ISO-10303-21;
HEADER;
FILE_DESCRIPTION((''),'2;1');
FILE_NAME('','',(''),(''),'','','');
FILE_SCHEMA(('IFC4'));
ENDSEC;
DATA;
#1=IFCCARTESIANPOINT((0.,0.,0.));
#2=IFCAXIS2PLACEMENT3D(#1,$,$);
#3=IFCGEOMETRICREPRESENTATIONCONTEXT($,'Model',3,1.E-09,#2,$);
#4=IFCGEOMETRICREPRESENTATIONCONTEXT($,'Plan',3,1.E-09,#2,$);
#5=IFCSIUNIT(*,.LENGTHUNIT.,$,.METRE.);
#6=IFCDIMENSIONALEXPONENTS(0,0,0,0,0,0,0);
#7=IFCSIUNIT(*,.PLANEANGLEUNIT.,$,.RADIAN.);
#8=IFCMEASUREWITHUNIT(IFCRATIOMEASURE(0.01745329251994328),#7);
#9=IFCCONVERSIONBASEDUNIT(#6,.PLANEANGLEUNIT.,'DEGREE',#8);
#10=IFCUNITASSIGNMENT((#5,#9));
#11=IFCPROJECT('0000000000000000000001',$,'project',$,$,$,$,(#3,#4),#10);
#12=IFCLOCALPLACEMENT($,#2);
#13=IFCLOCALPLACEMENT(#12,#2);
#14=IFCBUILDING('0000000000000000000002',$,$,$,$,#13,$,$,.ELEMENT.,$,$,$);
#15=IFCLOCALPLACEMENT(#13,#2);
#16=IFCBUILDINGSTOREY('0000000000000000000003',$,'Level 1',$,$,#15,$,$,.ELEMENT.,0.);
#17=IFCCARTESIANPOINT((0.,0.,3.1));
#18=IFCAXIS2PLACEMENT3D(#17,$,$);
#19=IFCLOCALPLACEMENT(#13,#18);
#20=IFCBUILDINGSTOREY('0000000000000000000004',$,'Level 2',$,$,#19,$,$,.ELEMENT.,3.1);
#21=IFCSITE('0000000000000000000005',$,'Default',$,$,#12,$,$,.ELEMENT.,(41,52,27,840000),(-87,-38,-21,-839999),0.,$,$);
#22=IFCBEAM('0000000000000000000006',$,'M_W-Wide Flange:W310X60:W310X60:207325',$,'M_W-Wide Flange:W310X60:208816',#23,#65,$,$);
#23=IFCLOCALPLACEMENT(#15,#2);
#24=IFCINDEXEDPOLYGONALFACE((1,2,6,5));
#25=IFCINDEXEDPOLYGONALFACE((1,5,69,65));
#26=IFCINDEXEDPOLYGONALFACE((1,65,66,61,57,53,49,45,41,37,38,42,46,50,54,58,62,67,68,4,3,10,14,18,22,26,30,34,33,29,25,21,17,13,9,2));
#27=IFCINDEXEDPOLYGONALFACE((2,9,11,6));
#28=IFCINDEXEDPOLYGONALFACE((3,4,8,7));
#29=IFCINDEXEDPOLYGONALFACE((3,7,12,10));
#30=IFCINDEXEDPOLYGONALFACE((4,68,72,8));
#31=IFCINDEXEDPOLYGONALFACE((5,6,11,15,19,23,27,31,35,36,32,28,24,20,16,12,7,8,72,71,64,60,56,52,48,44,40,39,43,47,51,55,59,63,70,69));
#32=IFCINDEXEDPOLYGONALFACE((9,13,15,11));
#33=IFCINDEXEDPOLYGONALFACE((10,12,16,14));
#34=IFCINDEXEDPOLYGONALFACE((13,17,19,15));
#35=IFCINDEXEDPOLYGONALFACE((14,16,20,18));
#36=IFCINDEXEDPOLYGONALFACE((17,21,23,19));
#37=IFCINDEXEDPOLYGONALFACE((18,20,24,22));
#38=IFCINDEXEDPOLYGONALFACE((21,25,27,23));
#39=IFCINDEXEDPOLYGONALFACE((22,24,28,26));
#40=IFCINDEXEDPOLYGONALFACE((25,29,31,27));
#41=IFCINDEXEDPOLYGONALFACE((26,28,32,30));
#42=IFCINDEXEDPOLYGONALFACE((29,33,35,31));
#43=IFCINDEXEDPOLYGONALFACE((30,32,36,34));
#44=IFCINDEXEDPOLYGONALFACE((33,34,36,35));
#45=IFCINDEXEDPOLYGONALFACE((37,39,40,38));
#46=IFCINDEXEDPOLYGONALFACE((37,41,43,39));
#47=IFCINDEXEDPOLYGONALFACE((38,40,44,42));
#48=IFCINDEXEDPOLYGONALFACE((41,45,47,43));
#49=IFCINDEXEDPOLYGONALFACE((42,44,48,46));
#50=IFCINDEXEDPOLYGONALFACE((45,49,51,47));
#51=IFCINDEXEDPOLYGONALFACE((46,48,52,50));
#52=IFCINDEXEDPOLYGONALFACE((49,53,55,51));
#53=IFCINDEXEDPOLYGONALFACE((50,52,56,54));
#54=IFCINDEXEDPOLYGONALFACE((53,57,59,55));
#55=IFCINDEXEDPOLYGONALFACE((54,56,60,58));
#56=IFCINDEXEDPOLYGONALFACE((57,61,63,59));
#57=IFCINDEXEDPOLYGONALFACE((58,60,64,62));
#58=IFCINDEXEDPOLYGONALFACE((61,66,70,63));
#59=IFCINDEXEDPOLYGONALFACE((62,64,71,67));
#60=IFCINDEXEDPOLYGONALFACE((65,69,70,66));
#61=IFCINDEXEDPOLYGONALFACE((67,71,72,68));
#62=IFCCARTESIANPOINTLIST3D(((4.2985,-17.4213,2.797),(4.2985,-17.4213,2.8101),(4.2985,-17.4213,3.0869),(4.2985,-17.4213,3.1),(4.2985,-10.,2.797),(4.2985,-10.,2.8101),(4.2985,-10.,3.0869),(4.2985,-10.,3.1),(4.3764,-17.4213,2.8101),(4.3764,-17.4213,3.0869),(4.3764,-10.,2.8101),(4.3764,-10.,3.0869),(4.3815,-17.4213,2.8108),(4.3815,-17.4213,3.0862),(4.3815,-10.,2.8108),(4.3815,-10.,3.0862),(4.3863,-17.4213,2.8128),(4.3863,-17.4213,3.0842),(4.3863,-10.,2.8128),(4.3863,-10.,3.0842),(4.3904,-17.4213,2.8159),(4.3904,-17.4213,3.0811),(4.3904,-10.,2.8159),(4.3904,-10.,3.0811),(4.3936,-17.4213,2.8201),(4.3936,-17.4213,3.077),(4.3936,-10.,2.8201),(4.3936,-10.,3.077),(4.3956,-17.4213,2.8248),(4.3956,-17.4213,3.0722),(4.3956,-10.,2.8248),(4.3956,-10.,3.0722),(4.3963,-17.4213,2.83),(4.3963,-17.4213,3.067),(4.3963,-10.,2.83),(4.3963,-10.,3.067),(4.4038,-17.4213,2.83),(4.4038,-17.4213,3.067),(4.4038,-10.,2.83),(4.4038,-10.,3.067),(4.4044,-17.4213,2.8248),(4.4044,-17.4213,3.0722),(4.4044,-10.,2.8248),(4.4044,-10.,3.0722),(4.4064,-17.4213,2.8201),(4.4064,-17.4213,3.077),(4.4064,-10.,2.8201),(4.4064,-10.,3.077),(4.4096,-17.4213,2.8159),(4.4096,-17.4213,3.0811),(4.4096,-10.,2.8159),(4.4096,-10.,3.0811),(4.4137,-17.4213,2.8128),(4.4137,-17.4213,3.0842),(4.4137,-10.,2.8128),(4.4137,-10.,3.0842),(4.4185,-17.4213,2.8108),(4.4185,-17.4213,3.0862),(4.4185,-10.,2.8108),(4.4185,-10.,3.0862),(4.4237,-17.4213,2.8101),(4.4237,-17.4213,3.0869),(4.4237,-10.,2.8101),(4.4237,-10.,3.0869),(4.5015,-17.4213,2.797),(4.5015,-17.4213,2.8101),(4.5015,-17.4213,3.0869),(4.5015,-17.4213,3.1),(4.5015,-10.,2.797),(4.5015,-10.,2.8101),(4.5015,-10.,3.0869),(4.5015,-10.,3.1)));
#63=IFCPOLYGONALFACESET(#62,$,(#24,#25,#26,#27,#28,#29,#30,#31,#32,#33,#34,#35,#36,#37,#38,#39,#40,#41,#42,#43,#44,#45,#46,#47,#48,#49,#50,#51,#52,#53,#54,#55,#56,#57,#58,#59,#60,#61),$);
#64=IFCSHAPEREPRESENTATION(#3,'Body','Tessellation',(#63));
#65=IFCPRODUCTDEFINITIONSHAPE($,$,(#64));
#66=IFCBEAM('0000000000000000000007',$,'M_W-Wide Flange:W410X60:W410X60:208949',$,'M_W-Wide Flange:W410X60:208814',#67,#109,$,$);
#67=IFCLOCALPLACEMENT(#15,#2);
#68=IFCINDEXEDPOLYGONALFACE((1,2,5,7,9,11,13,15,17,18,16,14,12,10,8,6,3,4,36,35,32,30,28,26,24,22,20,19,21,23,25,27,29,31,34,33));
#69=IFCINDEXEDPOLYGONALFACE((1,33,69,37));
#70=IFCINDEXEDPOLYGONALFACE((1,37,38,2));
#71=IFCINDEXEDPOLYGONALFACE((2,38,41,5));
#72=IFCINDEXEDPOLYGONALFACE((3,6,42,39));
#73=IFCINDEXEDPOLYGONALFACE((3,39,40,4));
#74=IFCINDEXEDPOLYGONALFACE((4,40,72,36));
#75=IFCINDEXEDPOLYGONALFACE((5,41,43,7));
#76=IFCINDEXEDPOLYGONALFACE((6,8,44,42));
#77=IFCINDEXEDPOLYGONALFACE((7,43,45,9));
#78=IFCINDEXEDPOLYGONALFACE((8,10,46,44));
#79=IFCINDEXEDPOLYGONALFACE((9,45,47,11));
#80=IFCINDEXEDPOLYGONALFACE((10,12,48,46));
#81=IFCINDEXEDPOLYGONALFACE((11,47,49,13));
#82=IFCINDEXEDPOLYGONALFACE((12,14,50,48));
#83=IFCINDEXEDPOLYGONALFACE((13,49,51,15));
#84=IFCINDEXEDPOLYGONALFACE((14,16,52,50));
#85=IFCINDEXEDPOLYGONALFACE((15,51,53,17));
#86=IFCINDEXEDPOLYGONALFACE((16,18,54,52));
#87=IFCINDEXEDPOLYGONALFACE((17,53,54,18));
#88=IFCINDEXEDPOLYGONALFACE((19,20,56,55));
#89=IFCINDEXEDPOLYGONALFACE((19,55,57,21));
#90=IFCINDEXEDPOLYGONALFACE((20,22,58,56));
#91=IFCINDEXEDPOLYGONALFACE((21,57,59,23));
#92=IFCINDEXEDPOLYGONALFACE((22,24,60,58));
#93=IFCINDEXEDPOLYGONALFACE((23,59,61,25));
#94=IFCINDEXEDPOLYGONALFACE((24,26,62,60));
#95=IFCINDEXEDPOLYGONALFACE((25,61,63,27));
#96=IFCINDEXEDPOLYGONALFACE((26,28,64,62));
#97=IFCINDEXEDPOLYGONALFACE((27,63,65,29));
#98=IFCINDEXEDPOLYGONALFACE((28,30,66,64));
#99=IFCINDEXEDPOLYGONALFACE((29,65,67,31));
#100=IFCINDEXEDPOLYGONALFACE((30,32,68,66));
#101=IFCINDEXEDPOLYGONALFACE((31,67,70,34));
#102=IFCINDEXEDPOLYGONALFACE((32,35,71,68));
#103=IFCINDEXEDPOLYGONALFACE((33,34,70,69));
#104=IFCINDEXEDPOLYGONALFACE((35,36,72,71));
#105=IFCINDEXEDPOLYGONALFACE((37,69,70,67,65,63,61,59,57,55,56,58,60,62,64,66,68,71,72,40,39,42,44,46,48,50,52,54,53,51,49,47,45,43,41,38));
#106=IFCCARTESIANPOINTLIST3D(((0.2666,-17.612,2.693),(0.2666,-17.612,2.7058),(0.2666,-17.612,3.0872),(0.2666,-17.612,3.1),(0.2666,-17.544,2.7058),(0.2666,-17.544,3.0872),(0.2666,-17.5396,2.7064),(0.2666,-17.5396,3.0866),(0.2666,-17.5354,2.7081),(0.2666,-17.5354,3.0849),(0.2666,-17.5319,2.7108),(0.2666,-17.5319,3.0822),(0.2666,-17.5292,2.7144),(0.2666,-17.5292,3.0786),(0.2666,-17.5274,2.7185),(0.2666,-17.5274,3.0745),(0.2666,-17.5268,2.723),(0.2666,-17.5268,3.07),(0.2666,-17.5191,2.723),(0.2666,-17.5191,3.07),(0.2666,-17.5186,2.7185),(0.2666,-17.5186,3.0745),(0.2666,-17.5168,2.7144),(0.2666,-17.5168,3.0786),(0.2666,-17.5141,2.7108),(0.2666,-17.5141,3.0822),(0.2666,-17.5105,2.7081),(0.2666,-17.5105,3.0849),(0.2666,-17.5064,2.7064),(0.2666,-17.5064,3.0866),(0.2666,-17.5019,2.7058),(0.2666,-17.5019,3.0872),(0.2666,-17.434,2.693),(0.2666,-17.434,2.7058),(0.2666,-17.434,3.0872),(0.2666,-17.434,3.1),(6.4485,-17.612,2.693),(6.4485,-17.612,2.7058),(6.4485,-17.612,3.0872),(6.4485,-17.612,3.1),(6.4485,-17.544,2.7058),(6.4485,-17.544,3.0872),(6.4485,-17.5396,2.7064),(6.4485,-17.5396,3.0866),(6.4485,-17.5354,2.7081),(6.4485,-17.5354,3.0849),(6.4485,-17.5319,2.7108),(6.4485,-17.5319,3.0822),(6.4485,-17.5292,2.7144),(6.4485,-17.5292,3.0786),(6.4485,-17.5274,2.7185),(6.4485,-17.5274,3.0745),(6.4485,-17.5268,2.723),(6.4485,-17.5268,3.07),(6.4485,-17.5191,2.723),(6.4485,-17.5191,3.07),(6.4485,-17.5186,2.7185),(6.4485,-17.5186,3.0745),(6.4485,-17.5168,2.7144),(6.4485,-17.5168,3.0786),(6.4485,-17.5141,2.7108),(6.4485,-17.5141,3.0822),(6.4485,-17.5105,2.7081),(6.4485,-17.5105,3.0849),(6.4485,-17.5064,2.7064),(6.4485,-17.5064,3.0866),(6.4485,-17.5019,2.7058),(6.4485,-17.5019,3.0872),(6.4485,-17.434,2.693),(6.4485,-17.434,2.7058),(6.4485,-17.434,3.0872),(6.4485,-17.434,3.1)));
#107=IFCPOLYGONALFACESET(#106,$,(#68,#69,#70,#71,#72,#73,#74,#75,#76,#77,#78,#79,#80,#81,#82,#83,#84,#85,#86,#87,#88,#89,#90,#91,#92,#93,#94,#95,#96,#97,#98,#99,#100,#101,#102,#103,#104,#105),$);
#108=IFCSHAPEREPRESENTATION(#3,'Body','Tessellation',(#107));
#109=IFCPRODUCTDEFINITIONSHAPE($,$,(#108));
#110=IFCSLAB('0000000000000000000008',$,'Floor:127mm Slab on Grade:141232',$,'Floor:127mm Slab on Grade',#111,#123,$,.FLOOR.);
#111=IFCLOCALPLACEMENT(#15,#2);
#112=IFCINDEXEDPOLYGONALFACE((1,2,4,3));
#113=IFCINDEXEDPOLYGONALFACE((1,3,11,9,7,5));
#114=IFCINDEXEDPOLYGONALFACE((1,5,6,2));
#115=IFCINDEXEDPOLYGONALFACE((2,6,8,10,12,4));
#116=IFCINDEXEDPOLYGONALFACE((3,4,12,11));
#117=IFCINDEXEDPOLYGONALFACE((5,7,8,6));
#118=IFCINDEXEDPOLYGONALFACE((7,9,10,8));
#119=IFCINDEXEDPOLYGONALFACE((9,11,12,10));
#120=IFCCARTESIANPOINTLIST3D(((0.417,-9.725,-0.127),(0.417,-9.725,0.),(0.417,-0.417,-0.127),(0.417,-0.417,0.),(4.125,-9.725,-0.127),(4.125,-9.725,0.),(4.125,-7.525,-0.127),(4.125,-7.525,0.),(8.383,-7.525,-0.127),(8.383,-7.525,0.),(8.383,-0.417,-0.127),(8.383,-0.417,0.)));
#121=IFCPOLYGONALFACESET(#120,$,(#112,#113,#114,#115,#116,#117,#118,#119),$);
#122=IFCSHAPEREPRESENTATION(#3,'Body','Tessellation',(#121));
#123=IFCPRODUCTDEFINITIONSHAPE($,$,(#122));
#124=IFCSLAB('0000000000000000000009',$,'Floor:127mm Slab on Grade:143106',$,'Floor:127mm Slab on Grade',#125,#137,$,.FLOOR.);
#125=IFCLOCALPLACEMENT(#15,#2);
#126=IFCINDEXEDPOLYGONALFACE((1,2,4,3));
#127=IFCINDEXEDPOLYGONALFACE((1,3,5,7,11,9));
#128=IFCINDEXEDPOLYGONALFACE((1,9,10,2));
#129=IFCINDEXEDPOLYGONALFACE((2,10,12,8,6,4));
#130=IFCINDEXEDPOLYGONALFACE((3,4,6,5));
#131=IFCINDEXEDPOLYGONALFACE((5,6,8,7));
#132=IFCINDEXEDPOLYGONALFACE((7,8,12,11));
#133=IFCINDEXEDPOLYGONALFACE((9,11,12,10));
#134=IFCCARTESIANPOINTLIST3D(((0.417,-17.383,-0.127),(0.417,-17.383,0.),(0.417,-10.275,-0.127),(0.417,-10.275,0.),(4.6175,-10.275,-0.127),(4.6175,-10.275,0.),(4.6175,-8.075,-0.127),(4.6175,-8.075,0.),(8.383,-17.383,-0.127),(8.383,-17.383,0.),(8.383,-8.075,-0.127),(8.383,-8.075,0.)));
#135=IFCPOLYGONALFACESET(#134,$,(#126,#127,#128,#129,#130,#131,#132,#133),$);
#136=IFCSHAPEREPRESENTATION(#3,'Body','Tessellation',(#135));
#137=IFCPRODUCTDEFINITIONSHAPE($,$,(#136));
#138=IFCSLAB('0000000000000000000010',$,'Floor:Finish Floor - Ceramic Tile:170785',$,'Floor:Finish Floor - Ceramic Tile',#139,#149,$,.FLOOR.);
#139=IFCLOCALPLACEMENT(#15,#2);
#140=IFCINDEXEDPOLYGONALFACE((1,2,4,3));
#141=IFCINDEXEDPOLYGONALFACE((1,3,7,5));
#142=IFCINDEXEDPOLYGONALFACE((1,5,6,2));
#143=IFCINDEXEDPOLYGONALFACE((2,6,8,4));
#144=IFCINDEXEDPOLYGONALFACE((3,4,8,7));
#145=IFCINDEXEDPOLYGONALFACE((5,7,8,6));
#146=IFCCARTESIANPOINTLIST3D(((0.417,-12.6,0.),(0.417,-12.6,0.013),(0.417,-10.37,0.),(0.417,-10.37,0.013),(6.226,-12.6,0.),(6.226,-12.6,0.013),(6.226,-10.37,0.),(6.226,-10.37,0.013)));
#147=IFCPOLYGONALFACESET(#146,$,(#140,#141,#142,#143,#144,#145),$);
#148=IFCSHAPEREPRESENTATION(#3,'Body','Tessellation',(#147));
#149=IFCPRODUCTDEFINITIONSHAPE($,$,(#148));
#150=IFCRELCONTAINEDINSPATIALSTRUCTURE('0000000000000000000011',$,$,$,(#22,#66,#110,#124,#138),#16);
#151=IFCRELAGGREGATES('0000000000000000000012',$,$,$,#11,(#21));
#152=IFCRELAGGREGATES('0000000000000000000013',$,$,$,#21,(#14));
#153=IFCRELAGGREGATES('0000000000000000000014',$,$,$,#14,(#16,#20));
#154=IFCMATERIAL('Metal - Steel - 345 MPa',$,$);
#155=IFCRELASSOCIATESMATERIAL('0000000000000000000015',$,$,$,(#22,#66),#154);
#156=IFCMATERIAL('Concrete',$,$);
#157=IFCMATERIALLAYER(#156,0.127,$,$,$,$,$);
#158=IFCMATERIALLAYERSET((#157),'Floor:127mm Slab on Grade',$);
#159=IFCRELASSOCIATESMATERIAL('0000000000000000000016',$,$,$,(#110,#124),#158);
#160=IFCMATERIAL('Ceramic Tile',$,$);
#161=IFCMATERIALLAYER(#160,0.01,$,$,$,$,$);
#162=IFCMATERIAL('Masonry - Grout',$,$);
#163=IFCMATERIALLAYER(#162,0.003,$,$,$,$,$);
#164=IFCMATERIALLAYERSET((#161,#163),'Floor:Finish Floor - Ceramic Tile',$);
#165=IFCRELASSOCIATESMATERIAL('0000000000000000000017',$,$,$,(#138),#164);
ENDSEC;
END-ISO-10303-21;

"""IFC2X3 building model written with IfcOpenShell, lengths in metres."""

from ifc_helpers import new_model, entity, si_unit, converted_unit, frame, frame_2d, origin, place, context, project, spatial, polyline, circle_curve, parameter, trimmed, segment, composite_curve, rectangle, outline, extrude, material, layer, layer_set, layer_usage, element, save


model = new_model("IFC2X3")

# Units and contexts
model_context = context("Model", 3, precision=1e-09, world=origin())
plan_context = context("Plan", 3, precision=1e-09, world=origin())
ifc_project = project(units=[si_unit("LENGTHUNIT", "METRE"), converted_unit("PLANEANGLEUNIT", "DEGREE", entity("IfcRatioMeasure", 0.01745329251994328), si_unit("PLANEANGLEUNIT", "RADIAN"), dimensions=[0, 0, 0, 0, 0, 0, 0])], contexts=[model_context, plan_context])

# Site, building, storey
site_placement = place(None, origin())
site = spatial("IfcSite", under=ifc_project, at=site_placement, Name="Default", CompositionType="ELEMENT", RefLatitude=(41, 52, 27, 840000), RefLongitude=(-87, -38, -21, -839999), RefElevation=0.0)
building_placement = place(site_placement, origin())
building = spatial("IfcBuilding", under=site, at=building_placement, CompositionType="ELEMENT")
storey_1_placement = place(building_placement, origin())
storey_1 = spatial("IfcBuildingStorey", under=building, at=storey_1_placement, Name="Level 1", CompositionType="ELEMENT", Elevation=0.0)

# Beams
ifc_material_1 = material(Name="Metal - Steel - 345 MPa")
beam_1_placement = place(storey_1_placement, frame((4.4, -10.0, 3.1), z_axis=(0.0, 0.0, 1.0), x_axis=(-1.0, 0.0, 0.0)))
element("IfcBeam", 1, at=beam_1_placement, inside=storey_1, material=ifc_material_1, Name="M_W-Wide Flange:W310X60:W310X60:207325", ObjectType="M_W-Wide Flange:W310X60:208816", context=model_context, shape_type="SweptSolid", body=[
    extrude(outline(composite_curve([segment(polyline([(0.1384, -0.1015), (0.1515, -0.1015)]), True, "CONTINUOUS"), segment(polyline([(0.1515, -0.1015), (0.1515, 0.1015)]), True, "CONTINUOUS"), segment(polyline([(0.1515, 0.1015), (0.1384, 0.1015)]), True, "CONTINUOUS"), segment(polyline([(0.1384, 0.1015), (0.1384, 0.0236)]), True, "CONTINUOUS"), segment(trimmed(circle_curve(frame_2d((0.1185, 0.0236), x_axis=(0.0, 1.0)), 0.0199), [parameter(180.0)], [parameter(270.0)], True, "PARAMETER"), False, "CONTINUOUS"), segment(polyline([(0.1185, 0.0037), (-0.1185, 0.0037)]), True, "CONTINUOUS"), segment(trimmed(circle_curve(frame_2d((-0.1185, 0.0236), x_axis=(0.0, 1.0)), 0.0199), [parameter(90.0)], [parameter(180.0)], True, "PARAMETER"), False, "CONTINUOUS"), segment(polyline([(-0.1384, 0.0236), (-0.1384, 0.1015)]), True, "CONTINUOUS"), segment(polyline([(-0.1384, 0.1015), (-0.1515, 0.1015)]), True, "CONTINUOUS"), segment(polyline([(-0.1515, 0.1015), (-0.1515, -0.1015)]), True, "CONTINUOUS"), segment(polyline([(-0.1515, -0.1015), (-0.1384, -0.1015)]), True, "CONTINUOUS"), segment(polyline([(-0.1384, -0.1015), (-0.1384, -0.0237)]), True, "CONTINUOUS"), segment(trimmed(circle_curve(frame_2d((-0.1185, -0.0237), x_axis=(0.0, 1.0)), 0.0199), [parameter(360.0)], [parameter(90.0)], True, "PARAMETER"), False, "CONTINUOUS"), segment(polyline([(-0.1185, -0.0038), (0.1185, -0.0038)]), True, "CONTINUOUS"), segment(trimmed(circle_curve(frame_2d((0.1185, -0.0237), x_axis=(0.0, 1.0)), 0.0199), [parameter(270.0)], [parameter(0.0)], True, "PARAMETER"), False, "CONTINUOUS"), segment(polyline([(0.1384, -0.0237), (0.1384, -0.1015)]), True, "CONTINUOUS")], self_intersect=False)), frame((0.0, 7.4213, -0.1515), z_axis=(0.0, -1.0, 0.0), x_axis=(0.0, 0.0, -1.0)), (0.0, 0.0, 1.0), 7.4213),
])
beam_2_placement = place(storey_1_placement, frame((0.2085, -17.523, 3.1), z_axis=(0.0, 0.0, 1.0), x_axis=(0.0, -1.0, 0.0)))
element("IfcBeam", 2, at=beam_2_placement, inside=storey_1, material=ifc_material_1, Name="M_W-Wide Flange:W410X60:W410X60:208949", ObjectType="M_W-Wide Flange:W410X60:208814", context=model_context, shape_type="SweptSolid", body=[
    extrude(outline(composite_curve([segment(polyline([(-0.089, -0.1907), (-0.089, -0.2035)]), True, "CONTINUOUS"), segment(polyline([(-0.089, -0.2035), (0.089, -0.2035)]), True, "CONTINUOUS"), segment(polyline([(0.089, -0.2035), (0.089, -0.1907)]), True, "CONTINUOUS"), segment(polyline([(0.089, -0.1907), (0.021, -0.1907)]), True, "CONTINUOUS"), segment(trimmed(circle_curve(frame_2d((0.021, -0.1735), x_axis=(0.0, -1.0)), 0.0172), [parameter(270.0)], [parameter(360.0)], True, "PARAMETER"), False, "CONTINUOUS"), segment(polyline([(0.0038, -0.1735), (0.0038, 0.1735)]), True, "CONTINUOUS"), segment(trimmed(circle_curve(frame_2d((0.021, 0.1735), x_axis=(-1.0, 0.0)), 0.0172), [parameter(270.0)], [parameter(360.0)], True, "PARAMETER"), False, "CONTINUOUS"), segment(polyline([(0.021, 0.1907), (0.089, 0.1907)]), True, "CONTINUOUS"), segment(polyline([(0.089, 0.1907), (0.089, 0.2035)]), True, "CONTINUOUS"), segment(polyline([(0.089, 0.2035), (-0.089, 0.2035)]), True, "CONTINUOUS"), segment(polyline([(-0.089, 0.2035), (-0.089, 0.1907)]), True, "CONTINUOUS"), segment(polyline([(-0.089, 0.1907), (-0.0211, 0.1907)]), True, "CONTINUOUS"), segment(trimmed(circle_curve(frame_2d((-0.0211, 0.1735), x_axis=(0.0, 1.0)), 0.0172), [parameter(270.0)], [parameter(0.0)], True, "PARAMETER"), False, "CONTINUOUS"), segment(polyline([(-0.0039, 0.1735), (-0.0039, -0.1735)]), True, "CONTINUOUS"), segment(trimmed(circle_curve(frame_2d((-0.0211, -0.1735), x_axis=(1.0, 0.0)), 0.0172), [parameter(270.0)], [parameter(0.0)], True, "PARAMETER"), False, "CONTINUOUS"), segment(polyline([(-0.0211, -0.1907), (-0.089, -0.1907)]), True, "CONTINUOUS")], self_intersect=False)), frame((0.0, 0.0581, -0.2035), z_axis=(0.0, -1.0, 0.0), x_axis=(1.0, 0.0, 0.0)), (0.0, 0.0, -1.0), 6.1819),
])

# Slabs
ifc_material_2 = material(Name="Concrete")
ifc_layer_1 = layer(ifc_material_2, 0.127)
ifc_layer_set_1 = layer_set([ifc_layer_1], Name="Floor:127mm Slab on Grade")
ifc_layer_usage_1 = layer_usage(ifc_layer_set_1, "AXIS3", "POSITIVE", 0.0)
slab_1_placement = place(storey_1_placement, frame((0.417, -9.725, -0.127)))
element("IfcSlab", 3, at=slab_1_placement, inside=storey_1, material=ifc_layer_usage_1, Name="Floor:127mm Slab on Grade:141232", ObjectType="Floor:127mm Slab on Grade", PredefinedType="FLOOR", context=model_context, shape_type="SweptSolid", body=[
    extrude(outline(polyline([(-3.983, 4.654), (-3.983, -2.454), (0.275, -2.454), (0.275, -4.654), (3.983, -4.654), (3.983, 4.654), (-3.983, 4.654)])), frame((3.983, 4.654, 0.127), z_axis=(0.0, 0.0, -1.0), x_axis=(-1.0, 0.0, 0.0)), (0.0, 0.0, 1.0), 0.127),
])
ifc_layer_usage_2 = layer_usage(ifc_layer_set_1, "AXIS3", "POSITIVE", 0.0)
slab_2_placement = place(storey_1_placement, frame((0.417, -17.383, -0.127)))
element("IfcSlab", 4, at=slab_2_placement, inside=storey_1, material=ifc_layer_usage_2, Name="Floor:127mm Slab on Grade:143106", ObjectType="Floor:127mm Slab on Grade", PredefinedType="FLOOR", context=model_context, shape_type="SweptSolid", body=[
    extrude(outline(polyline([(-3.983, 4.654), (-3.983, -4.654), (3.983, -4.654), (3.983, 2.454), (-0.2175, 2.454), (-0.2175, 4.654), (-3.983, 4.654)])), frame((3.983, 4.654, 0.127), z_axis=(0.0, 0.0, -1.0), x_axis=(-1.0, 0.0, 0.0)), (0.0, 0.0, 1.0), 0.127),
])
ifc_material_3 = material(Name="Ceramic Tile")
ifc_layer_2 = layer(ifc_material_3, 0.01)
ifc_material_4 = material(Name="Masonry - Grout")
ifc_layer_3 = layer(ifc_material_4, 0.003)
ifc_layer_set_2 = layer_set([ifc_layer_2, ifc_layer_3], Name="Floor:Finish Floor - Ceramic Tile")
ifc_layer_usage_3 = layer_usage(ifc_layer_set_2, "AXIS3", "POSITIVE", 0.0)
slab_3_placement = place(storey_1_placement, frame((0.417, -12.6, 0.0)))
element("IfcSlab", 5, at=slab_3_placement, inside=storey_1, material=ifc_layer_usage_3, Name="Floor:Finish Floor - Ceramic Tile:170785", ObjectType="Floor:Finish Floor - Ceramic Tile", PredefinedType="FLOOR", context=model_context, shape_type="SweptSolid", body=[
    extrude(rectangle(XDim=5.809, YDim=2.23, at=frame_2d((0.0, 0.0), x_axis=(-1.0, 0.0))), frame((2.9045, 1.115, 0.013), z_axis=(0.0, 0.0, -1.0), x_axis=(-1.0, 0.0, 0.0)), (0.0, 0.0, 1.0), 0.013),
])

# Shared definitions
storey_2_placement = place(building_placement, frame((0.0, 0.0, 3.1)))
storey_2 = spatial("IfcBuildingStorey", under=building, at=storey_2_placement, Name="Level 2", CompositionType="ELEMENT", Elevation=3.1)

save(model, "model.ifc")
